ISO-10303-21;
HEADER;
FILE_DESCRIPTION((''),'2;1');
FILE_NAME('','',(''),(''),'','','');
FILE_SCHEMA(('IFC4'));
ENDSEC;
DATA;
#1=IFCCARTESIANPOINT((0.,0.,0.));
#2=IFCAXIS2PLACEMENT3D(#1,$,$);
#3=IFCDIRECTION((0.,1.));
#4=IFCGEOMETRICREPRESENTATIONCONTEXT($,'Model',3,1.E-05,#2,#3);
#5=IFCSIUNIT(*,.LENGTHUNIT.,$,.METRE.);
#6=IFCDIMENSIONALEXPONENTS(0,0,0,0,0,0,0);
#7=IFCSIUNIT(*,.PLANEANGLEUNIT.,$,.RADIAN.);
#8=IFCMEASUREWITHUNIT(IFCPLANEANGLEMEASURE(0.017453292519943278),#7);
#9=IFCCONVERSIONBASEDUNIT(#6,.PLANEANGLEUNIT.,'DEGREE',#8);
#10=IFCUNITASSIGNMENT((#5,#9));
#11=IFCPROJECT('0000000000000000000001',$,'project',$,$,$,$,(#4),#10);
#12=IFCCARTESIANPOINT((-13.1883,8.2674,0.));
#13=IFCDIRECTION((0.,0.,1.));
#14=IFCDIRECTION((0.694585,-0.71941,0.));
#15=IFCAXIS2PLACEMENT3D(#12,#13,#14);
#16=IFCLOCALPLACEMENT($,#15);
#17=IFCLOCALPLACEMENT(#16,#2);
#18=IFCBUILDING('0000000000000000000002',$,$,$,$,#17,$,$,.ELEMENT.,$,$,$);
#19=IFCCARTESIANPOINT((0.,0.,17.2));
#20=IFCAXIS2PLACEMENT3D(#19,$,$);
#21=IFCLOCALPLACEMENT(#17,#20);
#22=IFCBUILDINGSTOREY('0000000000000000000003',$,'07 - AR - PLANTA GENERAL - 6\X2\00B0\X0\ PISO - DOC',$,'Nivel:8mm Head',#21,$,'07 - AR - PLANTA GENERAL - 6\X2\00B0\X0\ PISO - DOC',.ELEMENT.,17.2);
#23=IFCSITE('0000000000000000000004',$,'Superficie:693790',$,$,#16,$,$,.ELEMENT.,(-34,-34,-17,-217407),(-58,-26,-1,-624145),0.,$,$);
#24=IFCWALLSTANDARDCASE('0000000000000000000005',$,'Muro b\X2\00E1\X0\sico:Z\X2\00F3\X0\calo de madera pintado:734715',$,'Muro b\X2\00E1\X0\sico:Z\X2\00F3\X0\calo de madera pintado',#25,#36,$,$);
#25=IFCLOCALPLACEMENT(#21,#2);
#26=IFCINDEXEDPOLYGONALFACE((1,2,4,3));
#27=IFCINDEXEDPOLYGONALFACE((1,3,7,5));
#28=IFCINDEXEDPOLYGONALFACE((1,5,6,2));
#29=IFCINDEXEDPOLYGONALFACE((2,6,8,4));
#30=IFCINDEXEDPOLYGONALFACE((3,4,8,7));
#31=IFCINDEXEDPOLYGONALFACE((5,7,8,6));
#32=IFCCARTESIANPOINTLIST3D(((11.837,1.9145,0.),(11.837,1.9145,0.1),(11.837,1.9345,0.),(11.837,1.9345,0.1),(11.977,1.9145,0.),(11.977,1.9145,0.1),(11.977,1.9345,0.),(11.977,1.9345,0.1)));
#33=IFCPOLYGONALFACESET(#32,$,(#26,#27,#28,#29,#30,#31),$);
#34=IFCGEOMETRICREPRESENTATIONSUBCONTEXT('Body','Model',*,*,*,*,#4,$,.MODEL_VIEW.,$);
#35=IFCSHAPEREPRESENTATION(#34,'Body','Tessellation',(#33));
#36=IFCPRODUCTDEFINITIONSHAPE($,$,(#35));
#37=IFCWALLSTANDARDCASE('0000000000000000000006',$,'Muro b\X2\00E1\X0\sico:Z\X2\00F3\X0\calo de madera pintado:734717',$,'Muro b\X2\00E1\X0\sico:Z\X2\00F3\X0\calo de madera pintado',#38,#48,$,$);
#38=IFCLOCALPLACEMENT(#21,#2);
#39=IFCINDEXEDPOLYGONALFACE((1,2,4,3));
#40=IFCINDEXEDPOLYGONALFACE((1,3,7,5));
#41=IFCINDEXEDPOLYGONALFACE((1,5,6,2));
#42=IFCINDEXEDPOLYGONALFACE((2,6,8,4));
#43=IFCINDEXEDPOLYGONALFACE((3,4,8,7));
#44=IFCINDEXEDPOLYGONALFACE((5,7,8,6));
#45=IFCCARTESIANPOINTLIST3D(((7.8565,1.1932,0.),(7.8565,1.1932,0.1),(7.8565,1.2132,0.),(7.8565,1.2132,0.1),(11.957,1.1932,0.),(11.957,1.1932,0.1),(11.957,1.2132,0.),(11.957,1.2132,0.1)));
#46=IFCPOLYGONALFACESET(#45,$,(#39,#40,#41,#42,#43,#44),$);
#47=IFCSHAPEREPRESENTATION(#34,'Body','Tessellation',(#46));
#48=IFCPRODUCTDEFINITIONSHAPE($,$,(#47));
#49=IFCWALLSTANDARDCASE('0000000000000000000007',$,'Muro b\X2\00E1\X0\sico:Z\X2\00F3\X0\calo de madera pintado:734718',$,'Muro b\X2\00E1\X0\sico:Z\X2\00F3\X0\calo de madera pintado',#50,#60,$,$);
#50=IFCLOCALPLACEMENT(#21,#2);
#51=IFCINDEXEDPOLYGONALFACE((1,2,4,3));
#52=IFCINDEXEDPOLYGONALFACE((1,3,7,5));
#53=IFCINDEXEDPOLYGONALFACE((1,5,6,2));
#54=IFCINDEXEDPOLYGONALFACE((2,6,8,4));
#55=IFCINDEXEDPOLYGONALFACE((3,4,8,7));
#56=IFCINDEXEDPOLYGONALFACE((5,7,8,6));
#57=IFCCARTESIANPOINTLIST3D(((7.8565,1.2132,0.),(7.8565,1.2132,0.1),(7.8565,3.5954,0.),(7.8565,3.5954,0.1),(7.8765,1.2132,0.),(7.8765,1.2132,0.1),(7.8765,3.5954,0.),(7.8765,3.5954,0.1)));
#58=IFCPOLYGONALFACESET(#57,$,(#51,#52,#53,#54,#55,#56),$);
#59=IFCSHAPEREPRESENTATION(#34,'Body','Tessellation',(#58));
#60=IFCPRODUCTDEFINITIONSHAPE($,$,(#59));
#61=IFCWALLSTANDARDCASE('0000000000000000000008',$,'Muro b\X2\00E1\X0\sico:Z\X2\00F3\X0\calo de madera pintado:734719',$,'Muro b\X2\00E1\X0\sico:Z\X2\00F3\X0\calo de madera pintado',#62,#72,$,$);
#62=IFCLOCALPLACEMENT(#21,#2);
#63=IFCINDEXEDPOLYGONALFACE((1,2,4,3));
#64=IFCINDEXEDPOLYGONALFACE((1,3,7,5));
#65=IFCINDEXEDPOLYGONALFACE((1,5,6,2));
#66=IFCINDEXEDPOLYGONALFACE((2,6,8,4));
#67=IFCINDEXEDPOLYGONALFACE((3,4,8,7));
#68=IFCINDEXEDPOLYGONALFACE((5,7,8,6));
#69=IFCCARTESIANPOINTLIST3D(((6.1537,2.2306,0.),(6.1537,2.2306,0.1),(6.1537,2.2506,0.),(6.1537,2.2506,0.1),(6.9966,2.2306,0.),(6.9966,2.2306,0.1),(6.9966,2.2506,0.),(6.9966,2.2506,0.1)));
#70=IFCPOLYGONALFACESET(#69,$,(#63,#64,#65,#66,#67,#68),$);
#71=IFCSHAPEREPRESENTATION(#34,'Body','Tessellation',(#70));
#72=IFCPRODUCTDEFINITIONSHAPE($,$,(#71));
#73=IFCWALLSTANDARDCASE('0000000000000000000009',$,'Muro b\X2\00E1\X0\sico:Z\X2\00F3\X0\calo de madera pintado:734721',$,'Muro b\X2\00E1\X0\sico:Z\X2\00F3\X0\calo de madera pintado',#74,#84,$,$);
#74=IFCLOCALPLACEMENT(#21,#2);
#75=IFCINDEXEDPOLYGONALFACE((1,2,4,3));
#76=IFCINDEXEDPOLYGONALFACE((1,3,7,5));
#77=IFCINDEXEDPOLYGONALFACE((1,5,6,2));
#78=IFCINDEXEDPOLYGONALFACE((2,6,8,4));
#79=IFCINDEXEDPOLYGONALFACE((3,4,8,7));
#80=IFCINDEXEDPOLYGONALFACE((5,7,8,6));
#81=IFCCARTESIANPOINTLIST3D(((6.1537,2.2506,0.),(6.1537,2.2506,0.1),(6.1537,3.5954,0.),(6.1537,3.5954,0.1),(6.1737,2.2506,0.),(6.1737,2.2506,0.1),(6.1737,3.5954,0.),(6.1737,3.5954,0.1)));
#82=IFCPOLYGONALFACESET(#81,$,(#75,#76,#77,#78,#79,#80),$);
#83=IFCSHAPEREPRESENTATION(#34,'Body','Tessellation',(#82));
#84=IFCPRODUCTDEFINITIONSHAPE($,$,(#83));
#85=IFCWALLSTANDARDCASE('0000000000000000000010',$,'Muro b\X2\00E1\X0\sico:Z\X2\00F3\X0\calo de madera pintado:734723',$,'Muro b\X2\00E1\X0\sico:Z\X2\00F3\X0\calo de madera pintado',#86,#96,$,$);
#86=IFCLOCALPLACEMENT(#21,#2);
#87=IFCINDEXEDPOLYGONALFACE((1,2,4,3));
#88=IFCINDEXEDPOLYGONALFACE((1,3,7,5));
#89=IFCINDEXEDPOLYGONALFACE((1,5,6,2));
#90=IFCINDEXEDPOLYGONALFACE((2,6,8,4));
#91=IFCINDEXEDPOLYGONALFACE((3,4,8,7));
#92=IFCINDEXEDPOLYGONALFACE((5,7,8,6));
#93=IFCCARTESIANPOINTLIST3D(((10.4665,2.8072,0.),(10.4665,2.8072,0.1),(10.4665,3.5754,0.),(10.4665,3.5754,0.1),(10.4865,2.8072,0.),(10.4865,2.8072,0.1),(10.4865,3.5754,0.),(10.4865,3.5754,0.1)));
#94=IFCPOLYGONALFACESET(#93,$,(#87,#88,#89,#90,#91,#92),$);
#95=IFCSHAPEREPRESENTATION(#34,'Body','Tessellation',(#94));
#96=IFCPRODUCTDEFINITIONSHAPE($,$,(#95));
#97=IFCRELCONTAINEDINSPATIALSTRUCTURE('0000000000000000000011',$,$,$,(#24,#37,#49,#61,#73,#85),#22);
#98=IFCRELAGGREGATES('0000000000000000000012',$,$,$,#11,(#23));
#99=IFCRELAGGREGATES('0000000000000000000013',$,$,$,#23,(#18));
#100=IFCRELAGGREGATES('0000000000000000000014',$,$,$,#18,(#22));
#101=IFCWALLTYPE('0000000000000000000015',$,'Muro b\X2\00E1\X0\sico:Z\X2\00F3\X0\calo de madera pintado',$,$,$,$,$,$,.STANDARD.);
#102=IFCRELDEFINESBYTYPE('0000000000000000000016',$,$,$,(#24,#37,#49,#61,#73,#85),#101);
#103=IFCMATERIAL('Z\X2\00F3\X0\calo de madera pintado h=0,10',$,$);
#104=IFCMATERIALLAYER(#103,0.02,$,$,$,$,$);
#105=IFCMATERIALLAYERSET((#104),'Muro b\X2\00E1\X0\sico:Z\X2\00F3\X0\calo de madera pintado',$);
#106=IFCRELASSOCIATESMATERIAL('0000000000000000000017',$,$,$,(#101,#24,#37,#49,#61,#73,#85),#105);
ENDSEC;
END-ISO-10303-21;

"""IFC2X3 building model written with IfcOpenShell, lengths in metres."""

from ifc_helpers import new_model, entity, si_unit, converted_unit, direction, frame, frame_2d, origin, place, context, subcontext, project, spatial, rectangle, extrude, material, layer, layer_set, layer_usage, type_object, element, save


model = new_model("IFC2X3")

# Units and contexts
model_context = context("Model", 3, precision=1e-05, world=origin(), true_north=direction((0.0, 1.0)))
body_context = subcontext(model_context, "Body", "Model", "MODEL_VIEW")
ifc_project = project(units=[si_unit("LENGTHUNIT", "METRE"), converted_unit("PLANEANGLEUNIT", "DEGREE", entity("IfcPlaneAngleMeasure", 0.017453292519943278), si_unit("PLANEANGLEUNIT", "RADIAN"), dimensions=[0, 0, 0, 0, 0, 0, 0])], contexts=[model_context])

# Site, building, storey
site_placement = place(None, frame((-13.1883, 8.2674, 0.0), z_axis=(0.0, 0.0, 1.0), x_axis=(0.694585, -0.71941, 0.0)))
site = spatial("IfcSite", under=ifc_project, at=site_placement, Name="Superficie:693790", CompositionType="ELEMENT", RefLatitude=(-34, -34, -17, -217407), RefLongitude=(-58, -26, -1, -624145), RefElevation=0.0)
building_placement = place(site_placement, origin())
building = spatial("IfcBuilding", under=site, at=building_placement, CompositionType="ELEMENT")
storey_placement = place(building_placement, frame((0.0, 0.0, 17.2)))
storey = spatial("IfcBuildingStorey", under=building, at=storey_placement, Name="07 - AR - PLANTA GENERAL - 6° PISO - DOC", ObjectType="Nivel:8mm Head", LongName="07 - AR - PLANTA GENERAL - 6° PISO - DOC", CompositionType="ELEMENT", Elevation=17.2)

# Walls
ifc_material_1 = material(Name="Zócalo de madera pintado h=0,10")
ifc_layer_1 = layer(ifc_material_1, 0.02)
ifc_layer_set_1 = layer_set([ifc_layer_1], Name="Muro básico:Zócalo de madera pintado")
wall_type_1 = type_object("IfcWallType", Name="Muro básico:Zócalo de madera pintado", PredefinedType="STANDARD", material=ifc_layer_set_1)
ifc_layer_usage_1 = layer_usage(ifc_layer_set_1, "AXIS2", "NEGATIVE", 0.01)
wall_1_placement = place(storey_placement, frame((11.977, 1.9245, 0.0), z_axis=(0.0, 0.0, 1.0), x_axis=(-1.0, 0.0, 0.0)))
element("IfcWallStandardCase", 1, at=wall_1_placement, inside=storey, type_object=wall_type_1, material=ifc_layer_usage_1, Name="Muro básico:Zócalo de madera pintado:734715", ObjectType="Muro básico:Zócalo de madera pintado", context=body_context, shape_type="SweptSolid", body=[
    extrude(rectangle(XDim=0.14, YDim=0.02, at=frame_2d((0.07, 0.0), x_axis=(-1.0, 0.0))), origin(), (0.0, 0.0, 1.0), 0.1),
])
ifc_layer_usage_2 = layer_usage(ifc_layer_set_1, "AXIS2", "NEGATIVE", 0.01)
wall_2_placement = place(storey_placement, frame((7.8565, 1.2032, 0.0)))
element("IfcWallStandardCase", 2, at=wall_2_placement, inside=storey, type_object=wall_type_1, material=ifc_layer_usage_2, Name="Muro básico:Zócalo de madera pintado:734717", ObjectType="Muro básico:Zócalo de madera pintado", context=body_context, shape_type="SweptSolid", body=[
    extrude(rectangle(XDim=4.1005, YDim=0.02, at=frame_2d((2.0503, 0.0), x_axis=(-1.0, 0.0))), origin(), (0.0, 0.0, 1.0), 0.1),
])
ifc_layer_usage_3 = layer_usage(ifc_layer_set_1, "AXIS2", "NEGATIVE", 0.01)
wall_3_placement = place(storey_placement, frame((7.8665, 3.5954, 0.0), z_axis=(0.0, 0.0, 1.0), x_axis=(0.0, -1.0, 0.0)))
element("IfcWallStandardCase", 3, at=wall_3_placement, inside=storey, type_object=wall_type_1, material=ifc_layer_usage_3, Name="Muro básico:Zócalo de madera pintado:734718", ObjectType="Muro básico:Zócalo de madera pintado", context=body_context, shape_type="SweptSolid", body=[
    extrude(rectangle(XDim=2.3823, YDim=0.02, at=frame_2d((1.1911, 0.0), x_axis=(-1.0, 0.0))), origin(), (0.0, 0.0, 1.0), 0.1),
])
ifc_layer_usage_4 = layer_usage(ifc_layer_set_1, "AXIS2", "NEGATIVE", 0.01)
wall_4_placement = place(storey_placement, frame((6.9966, 2.2406, 0.0), z_axis=(0.0, 0.0, 1.0), x_axis=(-1.0, 0.0, 0.0)))
element("IfcWallStandardCase", 4, at=wall_4_placement, inside=storey, type_object=wall_type_1, material=ifc_layer_usage_4, Name="Muro básico:Zócalo de madera pintado:734719", ObjectType="Muro básico:Zócalo de madera pintado", context=body_context, shape_type="SweptSolid", body=[
    extrude(rectangle(XDim=0.843, YDim=0.02, at=frame_2d((0.4215, 0.0), x_axis=(-1.0, 0.0))), origin(), (0.0, 0.0, 1.0), 0.1),
])
ifc_layer_usage_5 = layer_usage(ifc_layer_set_1, "AXIS2", "NEGATIVE", 0.01)
wall_5_placement = place(storey_placement, frame((6.1637, 2.2506, 0.0), z_axis=(0.0, 0.0, 1.0), x_axis=(0.0, 1.0, 0.0)))
element("IfcWallStandardCase", 5, at=wall_5_placement, inside=storey, type_object=wall_type_1, material=ifc_layer_usage_5, Name="Muro básico:Zócalo de madera pintado:734721", ObjectType="Muro básico:Zócalo de madera pintado", context=body_context, shape_type="SweptSolid", body=[
    extrude(rectangle(XDim=1.3448, YDim=0.02, at=frame_2d((0.6724, 0.0), x_axis=(-1.0, 0.0))), origin(), (0.0, 0.0, 1.0), 0.1),
])
ifc_layer_usage_6 = layer_usage(ifc_layer_set_1, "AXIS2", "NEGATIVE", 0.01)
wall_6_placement = place(storey_placement, frame((10.4765, 2.8072, 0.0), z_axis=(0.0, 0.0, 1.0), x_axis=(0.0, 1.0, 0.0)))
element("IfcWallStandardCase", 6, at=wall_6_placement, inside=storey, type_object=wall_type_1, material=ifc_layer_usage_6, Name="Muro básico:Zócalo de madera pintado:734723", ObjectType="Muro básico:Zócalo de madera pintado", context=body_context, shape_type="SweptSolid", body=[
    extrude(rectangle(XDim=0.7683, YDim=0.02, at=frame_2d((0.3841, 0.0), x_axis=(-1.0, 0.0))), origin(), (0.0, 0.0, 1.0), 0.1),
])

save(model, "model.ifc")
